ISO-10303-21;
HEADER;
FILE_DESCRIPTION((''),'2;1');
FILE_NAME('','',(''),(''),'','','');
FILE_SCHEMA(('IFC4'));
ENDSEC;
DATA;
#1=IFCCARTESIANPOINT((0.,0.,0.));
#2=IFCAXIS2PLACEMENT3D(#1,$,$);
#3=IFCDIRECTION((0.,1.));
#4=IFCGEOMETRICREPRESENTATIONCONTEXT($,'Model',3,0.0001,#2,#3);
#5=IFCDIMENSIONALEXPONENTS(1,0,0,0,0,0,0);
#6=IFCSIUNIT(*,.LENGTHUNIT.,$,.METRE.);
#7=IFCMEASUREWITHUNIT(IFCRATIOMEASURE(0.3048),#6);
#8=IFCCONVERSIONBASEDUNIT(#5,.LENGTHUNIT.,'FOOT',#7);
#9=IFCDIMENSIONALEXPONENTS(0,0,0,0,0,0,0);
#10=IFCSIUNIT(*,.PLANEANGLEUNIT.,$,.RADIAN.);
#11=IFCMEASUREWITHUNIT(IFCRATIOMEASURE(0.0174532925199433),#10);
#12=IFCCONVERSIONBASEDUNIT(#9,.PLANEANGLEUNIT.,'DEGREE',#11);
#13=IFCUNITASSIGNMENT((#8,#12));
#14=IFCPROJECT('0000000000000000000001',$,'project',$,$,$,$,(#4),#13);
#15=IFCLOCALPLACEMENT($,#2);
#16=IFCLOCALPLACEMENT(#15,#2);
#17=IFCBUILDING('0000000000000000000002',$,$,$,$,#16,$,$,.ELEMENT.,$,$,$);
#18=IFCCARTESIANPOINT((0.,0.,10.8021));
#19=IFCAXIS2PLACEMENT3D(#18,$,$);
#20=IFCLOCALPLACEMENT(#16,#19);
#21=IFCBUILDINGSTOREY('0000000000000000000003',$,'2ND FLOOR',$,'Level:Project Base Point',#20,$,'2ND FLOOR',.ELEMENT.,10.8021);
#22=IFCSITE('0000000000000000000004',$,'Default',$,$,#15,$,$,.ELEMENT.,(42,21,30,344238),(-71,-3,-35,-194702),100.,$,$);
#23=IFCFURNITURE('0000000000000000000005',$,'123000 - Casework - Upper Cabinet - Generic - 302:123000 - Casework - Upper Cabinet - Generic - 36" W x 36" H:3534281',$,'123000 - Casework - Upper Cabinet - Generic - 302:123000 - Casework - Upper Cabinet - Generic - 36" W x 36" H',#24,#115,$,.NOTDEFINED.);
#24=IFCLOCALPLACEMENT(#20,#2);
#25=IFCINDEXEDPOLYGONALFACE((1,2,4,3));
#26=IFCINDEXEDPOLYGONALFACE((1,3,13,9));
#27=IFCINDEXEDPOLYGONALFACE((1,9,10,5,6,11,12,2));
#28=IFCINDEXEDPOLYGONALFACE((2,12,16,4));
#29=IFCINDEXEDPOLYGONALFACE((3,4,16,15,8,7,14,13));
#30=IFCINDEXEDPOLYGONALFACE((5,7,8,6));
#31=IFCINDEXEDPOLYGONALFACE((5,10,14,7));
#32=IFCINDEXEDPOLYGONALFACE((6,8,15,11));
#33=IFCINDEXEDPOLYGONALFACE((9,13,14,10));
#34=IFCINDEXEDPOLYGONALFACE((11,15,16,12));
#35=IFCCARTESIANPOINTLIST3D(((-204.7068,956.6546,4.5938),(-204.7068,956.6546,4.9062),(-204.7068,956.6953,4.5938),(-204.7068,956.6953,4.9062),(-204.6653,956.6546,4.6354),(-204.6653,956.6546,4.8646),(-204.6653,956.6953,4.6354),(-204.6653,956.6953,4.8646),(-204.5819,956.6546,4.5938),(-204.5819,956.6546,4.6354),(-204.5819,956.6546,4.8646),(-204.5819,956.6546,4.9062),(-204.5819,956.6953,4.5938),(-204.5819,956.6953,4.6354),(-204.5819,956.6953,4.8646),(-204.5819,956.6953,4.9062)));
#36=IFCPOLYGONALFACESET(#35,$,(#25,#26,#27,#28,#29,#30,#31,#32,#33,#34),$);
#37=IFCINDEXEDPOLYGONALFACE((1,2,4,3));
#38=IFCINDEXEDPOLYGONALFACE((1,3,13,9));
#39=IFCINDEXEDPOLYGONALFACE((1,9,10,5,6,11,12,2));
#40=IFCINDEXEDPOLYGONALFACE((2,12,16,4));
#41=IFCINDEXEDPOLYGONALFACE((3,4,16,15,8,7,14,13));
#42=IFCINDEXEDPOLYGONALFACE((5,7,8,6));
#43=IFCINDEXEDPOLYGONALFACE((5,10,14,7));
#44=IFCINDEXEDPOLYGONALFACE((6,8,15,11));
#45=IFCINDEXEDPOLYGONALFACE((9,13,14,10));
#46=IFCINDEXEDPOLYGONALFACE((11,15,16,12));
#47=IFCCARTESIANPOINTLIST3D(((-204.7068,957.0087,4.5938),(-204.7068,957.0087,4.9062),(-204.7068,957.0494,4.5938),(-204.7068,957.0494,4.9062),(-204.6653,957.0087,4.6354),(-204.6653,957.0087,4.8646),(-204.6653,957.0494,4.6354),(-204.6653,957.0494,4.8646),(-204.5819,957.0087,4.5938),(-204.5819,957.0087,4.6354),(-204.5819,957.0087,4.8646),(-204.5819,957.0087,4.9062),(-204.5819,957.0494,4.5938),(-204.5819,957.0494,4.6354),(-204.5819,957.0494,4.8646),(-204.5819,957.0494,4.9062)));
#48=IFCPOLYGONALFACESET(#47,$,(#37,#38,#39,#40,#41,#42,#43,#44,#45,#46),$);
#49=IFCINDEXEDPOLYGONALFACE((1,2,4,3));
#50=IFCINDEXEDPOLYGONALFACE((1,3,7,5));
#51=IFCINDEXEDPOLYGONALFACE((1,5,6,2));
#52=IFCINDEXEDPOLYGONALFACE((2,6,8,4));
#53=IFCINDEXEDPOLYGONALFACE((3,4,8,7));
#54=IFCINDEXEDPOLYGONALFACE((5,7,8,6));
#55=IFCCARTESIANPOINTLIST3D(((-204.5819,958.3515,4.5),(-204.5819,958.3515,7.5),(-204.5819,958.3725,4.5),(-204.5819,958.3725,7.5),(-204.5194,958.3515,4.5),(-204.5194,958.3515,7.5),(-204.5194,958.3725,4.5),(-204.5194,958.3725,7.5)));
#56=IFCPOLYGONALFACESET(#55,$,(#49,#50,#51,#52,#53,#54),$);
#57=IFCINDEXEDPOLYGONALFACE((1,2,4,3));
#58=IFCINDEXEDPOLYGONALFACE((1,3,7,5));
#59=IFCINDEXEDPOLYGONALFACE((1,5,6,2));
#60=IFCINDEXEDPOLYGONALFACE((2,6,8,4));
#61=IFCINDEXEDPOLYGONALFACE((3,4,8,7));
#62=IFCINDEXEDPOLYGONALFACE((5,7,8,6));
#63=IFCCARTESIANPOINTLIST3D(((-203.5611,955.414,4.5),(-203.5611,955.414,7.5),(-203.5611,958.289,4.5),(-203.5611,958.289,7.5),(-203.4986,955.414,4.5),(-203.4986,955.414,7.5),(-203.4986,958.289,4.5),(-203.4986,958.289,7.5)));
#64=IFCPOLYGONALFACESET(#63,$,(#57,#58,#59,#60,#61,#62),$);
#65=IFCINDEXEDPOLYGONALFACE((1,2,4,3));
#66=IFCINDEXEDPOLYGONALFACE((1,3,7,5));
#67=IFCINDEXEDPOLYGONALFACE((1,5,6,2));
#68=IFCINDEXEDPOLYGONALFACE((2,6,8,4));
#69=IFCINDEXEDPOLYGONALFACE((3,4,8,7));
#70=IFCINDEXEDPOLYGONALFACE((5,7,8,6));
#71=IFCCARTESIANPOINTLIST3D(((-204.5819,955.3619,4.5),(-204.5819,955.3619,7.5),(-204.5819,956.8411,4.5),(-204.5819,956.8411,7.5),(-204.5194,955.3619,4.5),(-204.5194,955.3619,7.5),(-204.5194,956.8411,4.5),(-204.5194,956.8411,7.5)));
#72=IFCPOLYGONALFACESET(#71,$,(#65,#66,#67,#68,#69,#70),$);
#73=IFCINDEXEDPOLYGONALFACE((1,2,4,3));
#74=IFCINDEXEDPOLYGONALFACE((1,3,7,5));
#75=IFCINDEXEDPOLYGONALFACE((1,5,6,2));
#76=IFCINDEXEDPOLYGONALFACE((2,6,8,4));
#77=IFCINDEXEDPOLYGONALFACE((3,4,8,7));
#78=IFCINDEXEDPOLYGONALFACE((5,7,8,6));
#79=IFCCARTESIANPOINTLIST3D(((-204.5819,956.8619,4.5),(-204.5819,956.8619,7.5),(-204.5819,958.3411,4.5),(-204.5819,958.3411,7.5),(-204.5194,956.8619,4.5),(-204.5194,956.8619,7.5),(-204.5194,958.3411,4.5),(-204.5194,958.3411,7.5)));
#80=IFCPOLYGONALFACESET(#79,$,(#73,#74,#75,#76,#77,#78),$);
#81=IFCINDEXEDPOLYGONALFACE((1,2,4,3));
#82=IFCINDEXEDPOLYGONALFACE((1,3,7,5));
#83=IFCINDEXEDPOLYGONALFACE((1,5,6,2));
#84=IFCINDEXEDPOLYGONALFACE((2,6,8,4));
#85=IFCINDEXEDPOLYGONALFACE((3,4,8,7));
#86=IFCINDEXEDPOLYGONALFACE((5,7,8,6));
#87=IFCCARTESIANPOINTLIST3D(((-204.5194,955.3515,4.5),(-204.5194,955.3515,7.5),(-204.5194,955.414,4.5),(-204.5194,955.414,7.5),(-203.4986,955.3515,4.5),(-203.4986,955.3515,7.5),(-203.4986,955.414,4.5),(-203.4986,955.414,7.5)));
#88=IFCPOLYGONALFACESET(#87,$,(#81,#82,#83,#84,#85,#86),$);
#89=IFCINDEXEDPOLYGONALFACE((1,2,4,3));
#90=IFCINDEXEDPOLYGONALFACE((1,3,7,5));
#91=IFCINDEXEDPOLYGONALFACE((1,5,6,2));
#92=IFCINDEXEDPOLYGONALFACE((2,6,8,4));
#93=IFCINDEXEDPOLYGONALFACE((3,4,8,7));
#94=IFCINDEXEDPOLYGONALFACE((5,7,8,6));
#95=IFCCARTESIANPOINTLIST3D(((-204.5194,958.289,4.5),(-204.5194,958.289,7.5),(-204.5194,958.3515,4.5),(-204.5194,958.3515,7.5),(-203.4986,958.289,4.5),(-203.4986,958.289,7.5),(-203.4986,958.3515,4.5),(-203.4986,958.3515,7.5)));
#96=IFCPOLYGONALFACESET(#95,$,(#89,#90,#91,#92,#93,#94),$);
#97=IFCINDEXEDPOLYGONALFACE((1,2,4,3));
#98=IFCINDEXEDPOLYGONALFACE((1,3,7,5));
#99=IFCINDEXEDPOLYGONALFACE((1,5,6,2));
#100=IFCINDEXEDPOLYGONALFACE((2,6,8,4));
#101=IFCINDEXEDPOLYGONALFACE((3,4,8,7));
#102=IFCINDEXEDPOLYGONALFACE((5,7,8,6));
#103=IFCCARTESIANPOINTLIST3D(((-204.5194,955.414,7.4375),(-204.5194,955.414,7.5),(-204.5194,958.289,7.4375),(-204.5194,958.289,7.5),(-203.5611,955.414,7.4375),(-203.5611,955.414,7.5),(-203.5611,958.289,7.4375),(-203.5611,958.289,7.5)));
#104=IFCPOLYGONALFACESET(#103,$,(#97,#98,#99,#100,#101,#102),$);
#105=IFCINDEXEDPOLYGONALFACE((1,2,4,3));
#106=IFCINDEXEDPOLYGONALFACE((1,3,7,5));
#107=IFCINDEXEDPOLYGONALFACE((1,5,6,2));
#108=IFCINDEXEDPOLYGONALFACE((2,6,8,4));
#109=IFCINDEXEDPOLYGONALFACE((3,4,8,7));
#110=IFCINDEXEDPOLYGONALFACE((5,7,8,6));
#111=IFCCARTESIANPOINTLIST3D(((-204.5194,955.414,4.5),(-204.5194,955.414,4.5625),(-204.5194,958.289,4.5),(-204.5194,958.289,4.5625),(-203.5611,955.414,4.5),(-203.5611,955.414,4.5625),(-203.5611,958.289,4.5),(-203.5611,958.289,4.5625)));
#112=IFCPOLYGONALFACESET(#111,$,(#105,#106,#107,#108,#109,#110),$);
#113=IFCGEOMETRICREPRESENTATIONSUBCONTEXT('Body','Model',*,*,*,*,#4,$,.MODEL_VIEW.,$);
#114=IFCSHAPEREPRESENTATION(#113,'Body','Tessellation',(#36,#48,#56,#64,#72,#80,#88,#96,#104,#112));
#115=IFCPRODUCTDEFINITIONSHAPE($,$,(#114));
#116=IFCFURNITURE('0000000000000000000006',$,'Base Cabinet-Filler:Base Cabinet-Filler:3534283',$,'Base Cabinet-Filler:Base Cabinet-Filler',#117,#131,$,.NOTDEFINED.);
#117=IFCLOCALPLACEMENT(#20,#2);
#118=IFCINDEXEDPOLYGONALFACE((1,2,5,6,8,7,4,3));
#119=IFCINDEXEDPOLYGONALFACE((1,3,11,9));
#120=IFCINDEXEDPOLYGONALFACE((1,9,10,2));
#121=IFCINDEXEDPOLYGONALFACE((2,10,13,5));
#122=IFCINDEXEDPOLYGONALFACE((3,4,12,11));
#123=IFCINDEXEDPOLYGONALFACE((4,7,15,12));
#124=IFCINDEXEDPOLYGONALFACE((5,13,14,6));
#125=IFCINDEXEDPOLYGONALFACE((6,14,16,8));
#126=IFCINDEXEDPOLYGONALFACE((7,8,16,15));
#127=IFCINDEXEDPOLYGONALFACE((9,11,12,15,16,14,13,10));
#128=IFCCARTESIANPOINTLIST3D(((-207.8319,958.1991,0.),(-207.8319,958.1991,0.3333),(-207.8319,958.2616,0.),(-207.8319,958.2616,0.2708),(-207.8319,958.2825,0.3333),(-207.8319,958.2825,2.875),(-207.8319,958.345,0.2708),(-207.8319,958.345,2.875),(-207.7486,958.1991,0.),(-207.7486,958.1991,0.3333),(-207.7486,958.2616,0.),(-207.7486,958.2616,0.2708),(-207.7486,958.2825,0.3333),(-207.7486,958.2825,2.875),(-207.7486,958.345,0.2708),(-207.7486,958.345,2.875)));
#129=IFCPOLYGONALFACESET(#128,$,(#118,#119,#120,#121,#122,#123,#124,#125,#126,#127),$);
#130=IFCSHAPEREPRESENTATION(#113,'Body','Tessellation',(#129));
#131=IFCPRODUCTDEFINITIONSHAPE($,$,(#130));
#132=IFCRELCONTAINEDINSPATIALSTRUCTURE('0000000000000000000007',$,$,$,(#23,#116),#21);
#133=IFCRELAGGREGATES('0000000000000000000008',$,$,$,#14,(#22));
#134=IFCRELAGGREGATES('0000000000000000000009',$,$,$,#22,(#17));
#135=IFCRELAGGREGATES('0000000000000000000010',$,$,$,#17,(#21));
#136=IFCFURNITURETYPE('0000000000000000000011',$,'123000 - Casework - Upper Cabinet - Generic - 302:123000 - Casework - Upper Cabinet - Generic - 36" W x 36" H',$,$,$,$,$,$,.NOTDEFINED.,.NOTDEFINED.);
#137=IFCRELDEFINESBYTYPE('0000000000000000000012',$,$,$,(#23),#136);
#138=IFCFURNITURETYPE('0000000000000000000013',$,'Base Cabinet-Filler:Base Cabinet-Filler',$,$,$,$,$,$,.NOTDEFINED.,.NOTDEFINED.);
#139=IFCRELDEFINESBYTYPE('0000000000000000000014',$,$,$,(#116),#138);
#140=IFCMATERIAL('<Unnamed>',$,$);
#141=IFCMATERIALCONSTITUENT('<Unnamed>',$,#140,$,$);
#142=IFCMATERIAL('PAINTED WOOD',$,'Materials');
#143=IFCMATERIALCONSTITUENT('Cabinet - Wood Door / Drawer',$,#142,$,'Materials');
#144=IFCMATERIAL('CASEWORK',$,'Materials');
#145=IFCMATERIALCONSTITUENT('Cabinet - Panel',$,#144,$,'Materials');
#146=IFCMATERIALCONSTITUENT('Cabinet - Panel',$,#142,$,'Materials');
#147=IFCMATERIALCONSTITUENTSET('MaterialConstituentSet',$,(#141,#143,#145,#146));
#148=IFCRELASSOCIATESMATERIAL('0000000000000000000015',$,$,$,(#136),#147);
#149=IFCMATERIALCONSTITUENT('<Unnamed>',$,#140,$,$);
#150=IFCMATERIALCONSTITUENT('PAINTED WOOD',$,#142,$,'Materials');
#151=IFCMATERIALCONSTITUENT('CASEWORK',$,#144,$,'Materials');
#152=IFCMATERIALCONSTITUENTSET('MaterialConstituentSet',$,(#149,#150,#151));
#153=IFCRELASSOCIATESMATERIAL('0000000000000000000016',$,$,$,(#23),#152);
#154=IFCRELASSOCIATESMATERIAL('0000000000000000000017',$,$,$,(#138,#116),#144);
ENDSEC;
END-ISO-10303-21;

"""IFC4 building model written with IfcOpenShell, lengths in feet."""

from ifc_helpers import new_model, entity, si_unit, converted_unit, direction, frame, frame_2d, origin, origin_2d_with_axis, place, context, subcontext, project, spatial, polyline, rectangle, outline, extrude, source, transform, mapped, material, constituent, constituent_set, type_object, type_shapes, element, save


model = new_model("IFC4")

# Units and contexts
model_context = context("Model", 3, precision=0.0001, world=origin(), true_north=direction((0.0, 1.0)))
body_context = subcontext(model_context, "Body", "Model", "MODEL_VIEW")
ifc_project = project(units=[converted_unit("LENGTHUNIT", "FOOT", entity("IfcRatioMeasure", 0.3048), si_unit("LENGTHUNIT", "METRE"), dimensions=[1, 0, 0, 0, 0, 0, 0]), converted_unit("PLANEANGLEUNIT", "DEGREE", entity("IfcRatioMeasure", 0.0174532925199433), si_unit("PLANEANGLEUNIT", "RADIAN"), dimensions=[0, 0, 0, 0, 0, 0, 0])], contexts=[model_context])

# Site, building, storey
site_placement = place(None, origin())
site = spatial("IfcSite", under=ifc_project, at=site_placement, Name="Default", CompositionType="ELEMENT", RefLatitude=(42, 21, 30, 344238), RefLongitude=(-71, -3, -35, -194702), RefElevation=100.0)
building_placement = place(site_placement, origin())
building = spatial("IfcBuilding", under=site, at=building_placement, CompositionType="ELEMENT")
storey_placement = place(building_placement, frame((0.0, 0.0, 10.8021)))
storey = spatial("IfcBuildingStorey", under=building, at=storey_placement, Name="2ND FLOOR", ObjectType="Level:Project Base Point", LongName="2ND FLOOR", CompositionType="ELEMENT", Elevation=10.8021)

# Furniture
ifc_material_1 = material(Name="CASEWORK", Category="Materials")
ifc_material_2 = material(Name="<Unnamed>")
ifc_material_3 = material(Name="PAINTED WOOD", Category="Materials")
ifc_constituent_1 = constituent(ifc_material_2, Name="<Unnamed>")
ifc_constituent_2 = constituent(ifc_material_3, Name="PAINTED WOOD", Category="Materials")
ifc_constituent_3 = constituent(ifc_material_1, Name="CASEWORK", Category="Materials")
ifc_constituent_set_1 = constituent_set(constituents=[ifc_constituent_1, ifc_constituent_2, ifc_constituent_3], Name="MaterialConstituentSet")
ifc_constituent_4 = constituent(ifc_material_2, Name="<Unnamed>")
ifc_constituent_5 = constituent(ifc_material_3, Name="Cabinet - Wood Door / Drawer", Category="Materials")
ifc_constituent_6 = constituent(ifc_material_1, Name="Cabinet - Panel", Category="Materials")
ifc_constituent_7 = constituent(ifc_material_3, Name="Cabinet - Panel", Category="Materials")
ifc_constituent_set_2 = constituent_set(constituents=[ifc_constituent_4, ifc_constituent_5, ifc_constituent_6, ifc_constituent_7], Name="MaterialConstituentSet")
furniture_type_1 = type_object("IfcFurnitureType", Name="123000 - Casework - Upper Cabinet - Generic - 302:123000 - Casework - Upper Cabinet - Generic - 36\" W x 36\" H", AssemblyPlace="NOTDEFINED", PredefinedType="NOTDEFINED", material=ifc_constituent_set_2)
shared_shape_1 = source(origin(), body_context, "Body", "SweptSolid", [
    extrude(outline(polyline([(-0.0521, -0.1146), (-0.0521, -0.1562), (0.0729, -0.1562), (0.0729, 0.1562), (-0.0521, 0.1562), (-0.0521, 0.1146), (0.0313, 0.1146), (0.0313, -0.1146), (-0.0521, -0.1146)])), frame((1.303, 1.1354, 0.25), z_axis=(-1.0, 0.0, 0.0), x_axis=(0.0, 1.0, 0.0)), (0.0, 0.0, -1.0), 0.0407),
    extrude(outline(polyline([(-0.0521, -0.1146), (-0.0521, -0.1562), (0.0729, -0.1562), (0.0729, 0.1562), (-0.0521, 0.1562), (-0.0521, 0.1146), (0.0313, 0.1146), (0.0313, -0.1146), (-0.0521, -0.1146)])), frame((1.6572, 1.1354, 0.25), z_axis=(-1.0, 0.0, 0.0), x_axis=(0.0, 1.0, 0.0)), (0.0, 0.0, -1.0), 0.0407),
    extrude(rectangle(XDim=0.021, YDim=0.0625, at=frame_2d((0.0, 0.0), x_axis=(1.0, 0.0))), frame((3.0105, 1.0521, 0.0)), (0.0, 0.0, 1.0), 3.0),
    extrude(rectangle(XDim=2.875, YDim=0.0625, at=frame_2d((0.0, 0.0), x_axis=(1.0, 0.0))), frame((1.5, 0.0313, 0.0), z_axis=(0.0, 0.0, 1.0), x_axis=(-1.0, 0.0, 0.0)), (0.0, 0.0, 1.0), 3.0),
    extrude(rectangle(XDim=1.4792, YDim=0.0625, at=origin_2d_with_axis()), frame((0.75, 1.0521, 0.0)), (0.0, 0.0, 1.0), 3.0),
    extrude(rectangle(XDim=1.4792, YDim=0.0625, at=origin_2d_with_axis()), frame((2.25, 1.0521, 0.0)), (0.0, 0.0, 1.0), 3.0),
    extrude(rectangle(XDim=1.0208, YDim=0.0625, at=origin_2d_with_axis()), frame((0.0312, 0.5104, 0.0), z_axis=(0.0, 0.0, 1.0), x_axis=(0.0, 1.0, 0.0)), (0.0, 0.0, 1.0), 3.0),
    extrude(rectangle(XDim=1.0208, YDim=0.0625, at=frame_2d((0.0, 0.0), x_axis=(1.0, 0.0))), frame((2.9688, 0.5104, 0.0), z_axis=(0.0, 0.0, 1.0), x_axis=(0.0, 1.0, 0.0)), (0.0, 0.0, 1.0), 3.0),
    extrude(rectangle(XDim=0.9583, YDim=2.875, at=frame_2d((0.0, 0.0), x_axis=(1.0, 0.0))), frame((1.5, 0.5417, 2.9375), z_axis=(0.0, 0.0, 1.0), x_axis=(0.0, 1.0, 0.0)), (0.0, 0.0, 1.0), 0.0625),
    extrude(rectangle(XDim=0.9583, YDim=2.875, at=frame_2d((0.0, 0.0), x_axis=(1.0, 0.0))), frame((1.5, 0.5417, 0.0), z_axis=(0.0, 0.0, 1.0), x_axis=(0.0, 1.0, 0.0)), (0.0, 0.0, 1.0), 0.0625),
])
type_shapes(furniture_type_1, [shared_shape_1])
furniture_1_placement = place(storey_placement, frame((-203.4986, 955.3515, 4.5), z_axis=(0.0, 0.0, 1.0), x_axis=(0.0, 1.0, 0.0)))
element("IfcFurniture", 1, at=furniture_1_placement, inside=storey, type_object=furniture_type_1, material=ifc_constituent_set_1, Name="123000 - Casework - Upper Cabinet - Generic - 302:123000 - Casework - Upper Cabinet - Generic - 36\" W x 36\" H:3534281", ObjectType="123000 - Casework - Upper Cabinet - Generic - 302:123000 - Casework - Upper Cabinet - Generic - 36\" W x 36\" H", PredefinedType="NOTDEFINED", context=body_context, shape_type="MappedRepresentation", body=[
    mapped(shared_shape_1, transform((0.0, 0.0, 0.0), scale=1.0)),
])
furniture_type_2 = type_object("IfcFurnitureType", Name="Base Cabinet-Filler:Base Cabinet-Filler", AssemblyPlace="NOTDEFINED", PredefinedType="NOTDEFINED", material=ifc_material_1)
shared_shape_2 = source(origin(), body_context, "Body", "SweptSolid", [
    extrude(outline(polyline([(-0.599, -0.0729), (2.0052, -0.0729), (2.0052, -0.0104), (-0.5365, -0.0104), (-0.5365, 0.0729), (-0.8698, 0.0729), (-0.8698, 0.0104), (-0.599, 0.0104), (-0.599, -0.0729)])), frame((0.0, 0.0729, 0.8698), z_axis=(1.0, 0.0, 0.0), x_axis=(0.0, 0.0, 1.0)), (0.0, 0.0, 1.0), 0.0833),
])
type_shapes(furniture_type_2, [shared_shape_2])
furniture_2_placement = place(storey_placement, frame((-207.8319, 958.1991, 0.0)))
element("IfcFurniture", 2, at=furniture_2_placement, inside=storey, type_object=furniture_type_2, material=ifc_material_1, Name="Base Cabinet-Filler:Base Cabinet-Filler:3534283", ObjectType="Base Cabinet-Filler:Base Cabinet-Filler", PredefinedType="NOTDEFINED", context=body_context, shape_type="MappedRepresentation", body=[
    mapped(shared_shape_2, transform((0.0, 0.0, 0.0), scale=1.0)),
])

save(model, "model.ifc")
